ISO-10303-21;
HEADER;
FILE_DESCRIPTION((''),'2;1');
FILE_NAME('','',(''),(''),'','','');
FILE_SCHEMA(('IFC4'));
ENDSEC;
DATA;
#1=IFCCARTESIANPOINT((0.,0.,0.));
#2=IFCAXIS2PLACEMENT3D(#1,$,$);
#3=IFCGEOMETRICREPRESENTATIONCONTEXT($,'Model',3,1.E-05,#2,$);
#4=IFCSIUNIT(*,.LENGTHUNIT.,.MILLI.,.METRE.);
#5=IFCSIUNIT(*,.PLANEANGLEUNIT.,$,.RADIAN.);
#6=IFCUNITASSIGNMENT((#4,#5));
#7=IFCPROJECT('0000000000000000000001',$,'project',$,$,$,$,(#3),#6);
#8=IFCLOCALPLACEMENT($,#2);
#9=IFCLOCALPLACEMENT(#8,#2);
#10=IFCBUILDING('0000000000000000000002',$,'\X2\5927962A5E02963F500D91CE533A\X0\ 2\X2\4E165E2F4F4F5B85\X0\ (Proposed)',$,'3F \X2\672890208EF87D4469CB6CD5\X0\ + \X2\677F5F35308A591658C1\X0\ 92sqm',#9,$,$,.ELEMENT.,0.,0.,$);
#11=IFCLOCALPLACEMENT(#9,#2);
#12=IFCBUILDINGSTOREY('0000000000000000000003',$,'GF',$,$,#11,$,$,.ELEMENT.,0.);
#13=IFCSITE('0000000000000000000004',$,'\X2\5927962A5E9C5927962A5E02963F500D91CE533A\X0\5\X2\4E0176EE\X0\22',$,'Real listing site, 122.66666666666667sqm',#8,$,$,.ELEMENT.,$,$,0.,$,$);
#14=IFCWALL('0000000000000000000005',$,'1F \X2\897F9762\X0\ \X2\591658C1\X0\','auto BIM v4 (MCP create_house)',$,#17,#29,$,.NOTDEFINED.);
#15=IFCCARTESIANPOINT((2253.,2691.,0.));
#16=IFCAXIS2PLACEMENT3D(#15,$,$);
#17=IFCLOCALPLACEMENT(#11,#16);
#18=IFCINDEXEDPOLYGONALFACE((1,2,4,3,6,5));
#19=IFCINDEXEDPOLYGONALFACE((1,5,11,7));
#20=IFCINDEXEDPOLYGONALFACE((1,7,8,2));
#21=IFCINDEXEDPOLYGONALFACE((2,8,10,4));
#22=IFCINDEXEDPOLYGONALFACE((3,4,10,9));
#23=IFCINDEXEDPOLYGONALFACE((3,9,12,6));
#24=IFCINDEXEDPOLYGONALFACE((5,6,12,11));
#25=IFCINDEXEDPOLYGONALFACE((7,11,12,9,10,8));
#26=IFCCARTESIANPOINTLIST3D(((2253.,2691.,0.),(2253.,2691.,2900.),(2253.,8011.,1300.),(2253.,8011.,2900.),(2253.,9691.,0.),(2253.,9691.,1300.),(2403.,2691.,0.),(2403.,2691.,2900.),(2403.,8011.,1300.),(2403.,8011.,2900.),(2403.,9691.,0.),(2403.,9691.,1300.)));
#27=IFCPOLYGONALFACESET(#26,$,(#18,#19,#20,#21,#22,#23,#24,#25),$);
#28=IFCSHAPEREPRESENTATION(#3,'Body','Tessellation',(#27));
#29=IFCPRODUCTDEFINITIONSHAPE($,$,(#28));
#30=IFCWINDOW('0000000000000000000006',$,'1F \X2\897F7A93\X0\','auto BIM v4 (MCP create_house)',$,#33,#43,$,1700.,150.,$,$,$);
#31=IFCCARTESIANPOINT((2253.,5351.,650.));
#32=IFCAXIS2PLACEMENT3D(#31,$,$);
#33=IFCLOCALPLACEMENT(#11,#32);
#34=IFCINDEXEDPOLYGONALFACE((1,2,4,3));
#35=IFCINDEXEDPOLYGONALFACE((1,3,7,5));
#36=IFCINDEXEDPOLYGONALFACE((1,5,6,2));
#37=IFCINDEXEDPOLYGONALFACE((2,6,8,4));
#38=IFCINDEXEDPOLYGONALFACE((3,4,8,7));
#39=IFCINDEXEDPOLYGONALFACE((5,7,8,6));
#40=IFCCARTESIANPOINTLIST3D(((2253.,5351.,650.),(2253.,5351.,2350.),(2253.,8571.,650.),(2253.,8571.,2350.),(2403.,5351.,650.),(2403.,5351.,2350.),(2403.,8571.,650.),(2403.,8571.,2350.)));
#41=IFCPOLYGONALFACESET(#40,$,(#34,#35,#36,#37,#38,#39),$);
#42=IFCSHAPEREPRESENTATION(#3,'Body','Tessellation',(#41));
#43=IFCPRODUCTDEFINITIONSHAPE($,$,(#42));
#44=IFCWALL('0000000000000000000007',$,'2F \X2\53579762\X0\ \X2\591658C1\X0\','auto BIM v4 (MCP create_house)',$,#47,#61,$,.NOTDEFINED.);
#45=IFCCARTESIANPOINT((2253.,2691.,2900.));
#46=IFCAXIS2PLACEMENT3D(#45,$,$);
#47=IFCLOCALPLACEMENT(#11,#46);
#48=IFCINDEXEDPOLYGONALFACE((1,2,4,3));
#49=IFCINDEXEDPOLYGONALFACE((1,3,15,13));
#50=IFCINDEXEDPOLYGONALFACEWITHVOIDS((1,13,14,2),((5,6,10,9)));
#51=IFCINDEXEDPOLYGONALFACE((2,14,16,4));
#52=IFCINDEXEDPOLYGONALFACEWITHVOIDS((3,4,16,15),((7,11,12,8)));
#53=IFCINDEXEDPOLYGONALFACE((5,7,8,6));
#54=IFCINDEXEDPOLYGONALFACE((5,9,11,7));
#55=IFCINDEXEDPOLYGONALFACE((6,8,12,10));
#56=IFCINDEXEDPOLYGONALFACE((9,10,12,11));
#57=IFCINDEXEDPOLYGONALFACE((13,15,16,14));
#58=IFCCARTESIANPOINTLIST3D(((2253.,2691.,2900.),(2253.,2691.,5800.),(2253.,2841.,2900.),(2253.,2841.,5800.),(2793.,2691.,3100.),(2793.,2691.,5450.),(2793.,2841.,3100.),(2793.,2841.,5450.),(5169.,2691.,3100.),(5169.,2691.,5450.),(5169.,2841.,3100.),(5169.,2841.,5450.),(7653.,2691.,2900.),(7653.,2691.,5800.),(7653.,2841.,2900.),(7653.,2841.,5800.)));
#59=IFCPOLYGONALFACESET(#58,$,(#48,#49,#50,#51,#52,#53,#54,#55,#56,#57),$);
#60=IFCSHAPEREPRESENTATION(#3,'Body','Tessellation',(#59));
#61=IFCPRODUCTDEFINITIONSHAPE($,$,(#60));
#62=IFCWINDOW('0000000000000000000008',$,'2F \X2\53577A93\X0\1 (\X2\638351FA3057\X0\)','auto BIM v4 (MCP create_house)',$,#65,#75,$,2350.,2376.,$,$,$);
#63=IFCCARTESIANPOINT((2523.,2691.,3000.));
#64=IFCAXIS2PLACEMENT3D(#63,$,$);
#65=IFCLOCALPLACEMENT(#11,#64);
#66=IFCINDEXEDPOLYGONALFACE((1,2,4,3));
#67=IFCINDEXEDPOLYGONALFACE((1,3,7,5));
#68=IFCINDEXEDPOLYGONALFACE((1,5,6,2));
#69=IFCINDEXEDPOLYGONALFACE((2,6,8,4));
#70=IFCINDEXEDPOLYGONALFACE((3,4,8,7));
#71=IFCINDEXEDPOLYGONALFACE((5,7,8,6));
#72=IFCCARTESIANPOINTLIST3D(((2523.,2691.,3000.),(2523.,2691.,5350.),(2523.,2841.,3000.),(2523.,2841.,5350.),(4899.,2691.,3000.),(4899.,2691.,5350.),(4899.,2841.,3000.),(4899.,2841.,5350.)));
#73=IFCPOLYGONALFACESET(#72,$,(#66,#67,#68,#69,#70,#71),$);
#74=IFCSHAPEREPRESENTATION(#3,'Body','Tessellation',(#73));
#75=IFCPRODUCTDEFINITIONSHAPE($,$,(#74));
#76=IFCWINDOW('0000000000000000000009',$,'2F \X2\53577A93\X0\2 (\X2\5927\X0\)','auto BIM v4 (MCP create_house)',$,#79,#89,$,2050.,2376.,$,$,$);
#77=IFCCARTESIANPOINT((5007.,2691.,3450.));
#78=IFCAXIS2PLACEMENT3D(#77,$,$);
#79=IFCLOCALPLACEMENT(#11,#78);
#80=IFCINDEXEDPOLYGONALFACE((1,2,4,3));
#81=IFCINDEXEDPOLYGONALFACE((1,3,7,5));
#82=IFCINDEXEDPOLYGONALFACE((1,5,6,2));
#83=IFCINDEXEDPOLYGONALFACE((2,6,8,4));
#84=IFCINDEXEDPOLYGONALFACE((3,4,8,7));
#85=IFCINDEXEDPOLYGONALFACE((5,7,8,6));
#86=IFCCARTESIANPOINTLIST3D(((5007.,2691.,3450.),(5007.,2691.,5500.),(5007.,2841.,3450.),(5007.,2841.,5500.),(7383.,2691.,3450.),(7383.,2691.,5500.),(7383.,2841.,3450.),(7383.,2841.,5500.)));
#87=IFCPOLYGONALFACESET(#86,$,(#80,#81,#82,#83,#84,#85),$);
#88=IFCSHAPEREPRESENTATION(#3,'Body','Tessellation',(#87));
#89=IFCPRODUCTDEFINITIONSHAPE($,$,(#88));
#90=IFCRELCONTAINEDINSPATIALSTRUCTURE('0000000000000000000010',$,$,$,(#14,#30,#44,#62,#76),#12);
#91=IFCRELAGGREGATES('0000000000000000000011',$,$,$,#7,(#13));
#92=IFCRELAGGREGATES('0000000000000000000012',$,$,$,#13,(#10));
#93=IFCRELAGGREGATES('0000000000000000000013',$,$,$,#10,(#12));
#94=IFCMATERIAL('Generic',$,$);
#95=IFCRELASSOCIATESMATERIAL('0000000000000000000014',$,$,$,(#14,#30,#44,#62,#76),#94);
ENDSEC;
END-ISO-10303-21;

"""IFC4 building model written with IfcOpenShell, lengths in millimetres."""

from ifc_helpers import new_model, si_unit, frame, frame_2d, origin, place, context, project, spatial, rectangle, extrude, material, element, fill, save


model = new_model("IFC4")

# Units and contexts
model_context = context("Model", 3, precision=1e-05, world=origin())
ifc_project = project(units=[si_unit("LENGTHUNIT", "METRE", prefix="MILLI"), si_unit("PLANEANGLEUNIT", "RADIAN")], contexts=[model_context])

# Site, building, storey
site_placement = place(None, origin())
site = spatial("IfcSite", under=ifc_project, at=site_placement, Name="大阪府大阪市阿倍野区5丁目22", ObjectType="Real listing site, 122.66666666666667sqm", CompositionType="ELEMENT", RefElevation=0.0)
building_placement = place(site_placement, origin())
building = spatial("IfcBuilding", under=site, at=building_placement, Name="大阪市阿倍野区 2世帯住宅 (Proposed)", ObjectType="3F 木造軸組構法 + 板張り外壁 92sqm", CompositionType="ELEMENT", ElevationOfRefHeight=0.0, ElevationOfTerrain=0.0)
storey_placement = place(building_placement, origin())
storey = spatial("IfcBuildingStorey", under=building, at=storey_placement, Name="GF", CompositionType="ELEMENT", Elevation=0.0)

# Shared definitions
ifc_material = material(Name="Generic")

# Wall, opening, window
wall_1_placement = place(storey_placement, frame((2253.0, 2691.0, 0.0)))
wall_1 = element("IfcWall", 1, at=wall_1_placement, inside=storey, material=ifc_material, Name="1F 西面 外壁", Description="auto BIM v4 (MCP create_house)", PredefinedType="NOTDEFINED", context=model_context, shape_type="SweptSolid", body=[
    extrude(rectangle(XDim=150.0, YDim=7000.0, at=frame_2d((75.0, 3500.0))), frame((2253.0, 2691.0, 0.0)), (0.0, 0.0, 1.0), 2900.0),
])
opening_1_placement = place(storey_placement, frame((2253.0, 5351.0, 650.0)))
opening_1 = element("IfcOpeningElement", 2, at=opening_1_placement, cuts=wall_1, PredefinedType="NOTDEFINED", context=model_context, shape_type="SweptSolid", body=[
    extrude(rectangle(XDim=150.0, YDim=3220.0, at=frame_2d((75.0, 1610.0))), frame((2253.0, 5351.0, 650.0)), (0.0, 0.0, 1.0), 1700.0),
])
window_1_placement = place(storey_placement, frame((2253.0, 5351.0, 650.0)))
window_1 = element("IfcWindow", 3, at=window_1_placement, inside=storey, material=ifc_material, Name="1F 西窓", Description="auto BIM v4 (MCP create_house)", OverallHeight=1700.0, OverallWidth=150.0, context=model_context, shape_type="SweptSolid", body=[
    extrude(rectangle(XDim=150.0, YDim=3220.0, at=frame_2d((75.0, 1610.0))), frame((2253.0, 5351.0, 650.0)), (0.0, 0.0, 1.0), 1700.0),
])
fill(opening_1, window_1)

# Wall, openings, windows
wall_2_placement = place(storey_placement, frame((2253.0, 2691.0, 2900.0)))
wall_2 = element("IfcWall", 4, at=wall_2_placement, inside=storey, material=ifc_material, Name="2F 南面 外壁", Description="auto BIM v4 (MCP create_house)", PredefinedType="NOTDEFINED", context=model_context, shape_type="SweptSolid", body=[
    extrude(rectangle(XDim=5400.0, YDim=150.0, at=frame_2d((2700.0, 75.0))), frame((2253.0, 2691.0, 2900.0)), (0.0, 0.0, 1.0), 2900.0),
])
opening_2_placement = place(storey_placement, frame((2523.0, 2691.0, 3000.0)))
opening_2 = element("IfcOpeningElement", 5, at=opening_2_placement, cuts=wall_2, PredefinedType="NOTDEFINED", context=model_context, shape_type="SweptSolid", body=[
    extrude(rectangle(XDim=2376.0, YDim=150.0, at=frame_2d((1188.0, 75.0))), frame((2523.0, 2691.0, 3000.0)), (0.0, 0.0, 1.0), 2350.0),
])
opening_3_placement = place(storey_placement, frame((5007.0, 2691.0, 3450.0)))
opening_3 = element("IfcOpeningElement", 6, at=opening_3_placement, cuts=wall_2, PredefinedType="NOTDEFINED", context=model_context, shape_type="SweptSolid", body=[
    extrude(rectangle(XDim=2376.0, YDim=150.0, at=frame_2d((1188.0, 75.0))), frame((5007.0, 2691.0, 3450.0)), (0.0, 0.0, 1.0), 2050.0),
])
window_2_placement = place(storey_placement, frame((2523.0, 2691.0, 3000.0)))
window_2 = element("IfcWindow", 7, at=window_2_placement, inside=storey, material=ifc_material, Name="2F 南窓1 (掃出し)", Description="auto BIM v4 (MCP create_house)", OverallHeight=2350.0, OverallWidth=2376.0, context=model_context, shape_type="SweptSolid", body=[
    extrude(rectangle(XDim=2376.0, YDim=150.0, at=frame_2d((1188.0, 75.0))), frame((2523.0, 2691.0, 3000.0)), (0.0, 0.0, 1.0), 2350.0),
])
fill(opening_2, window_2)
window_3_placement = place(storey_placement, frame((5007.0, 2691.0, 3450.0)))
window_3 = element("IfcWindow", 8, at=window_3_placement, inside=storey, material=ifc_material, Name="2F 南窓2 (大)", Description="auto BIM v4 (MCP create_house)", OverallHeight=2050.0, OverallWidth=2376.0, context=model_context, shape_type="SweptSolid", body=[
    extrude(rectangle(XDim=2376.0, YDim=150.0, at=frame_2d((1188.0, 75.0))), frame((5007.0, 2691.0, 3450.0)), (0.0, 0.0, 1.0), 2050.0),
])
fill(opening_3, window_3)

save(model, "model.ifc")
